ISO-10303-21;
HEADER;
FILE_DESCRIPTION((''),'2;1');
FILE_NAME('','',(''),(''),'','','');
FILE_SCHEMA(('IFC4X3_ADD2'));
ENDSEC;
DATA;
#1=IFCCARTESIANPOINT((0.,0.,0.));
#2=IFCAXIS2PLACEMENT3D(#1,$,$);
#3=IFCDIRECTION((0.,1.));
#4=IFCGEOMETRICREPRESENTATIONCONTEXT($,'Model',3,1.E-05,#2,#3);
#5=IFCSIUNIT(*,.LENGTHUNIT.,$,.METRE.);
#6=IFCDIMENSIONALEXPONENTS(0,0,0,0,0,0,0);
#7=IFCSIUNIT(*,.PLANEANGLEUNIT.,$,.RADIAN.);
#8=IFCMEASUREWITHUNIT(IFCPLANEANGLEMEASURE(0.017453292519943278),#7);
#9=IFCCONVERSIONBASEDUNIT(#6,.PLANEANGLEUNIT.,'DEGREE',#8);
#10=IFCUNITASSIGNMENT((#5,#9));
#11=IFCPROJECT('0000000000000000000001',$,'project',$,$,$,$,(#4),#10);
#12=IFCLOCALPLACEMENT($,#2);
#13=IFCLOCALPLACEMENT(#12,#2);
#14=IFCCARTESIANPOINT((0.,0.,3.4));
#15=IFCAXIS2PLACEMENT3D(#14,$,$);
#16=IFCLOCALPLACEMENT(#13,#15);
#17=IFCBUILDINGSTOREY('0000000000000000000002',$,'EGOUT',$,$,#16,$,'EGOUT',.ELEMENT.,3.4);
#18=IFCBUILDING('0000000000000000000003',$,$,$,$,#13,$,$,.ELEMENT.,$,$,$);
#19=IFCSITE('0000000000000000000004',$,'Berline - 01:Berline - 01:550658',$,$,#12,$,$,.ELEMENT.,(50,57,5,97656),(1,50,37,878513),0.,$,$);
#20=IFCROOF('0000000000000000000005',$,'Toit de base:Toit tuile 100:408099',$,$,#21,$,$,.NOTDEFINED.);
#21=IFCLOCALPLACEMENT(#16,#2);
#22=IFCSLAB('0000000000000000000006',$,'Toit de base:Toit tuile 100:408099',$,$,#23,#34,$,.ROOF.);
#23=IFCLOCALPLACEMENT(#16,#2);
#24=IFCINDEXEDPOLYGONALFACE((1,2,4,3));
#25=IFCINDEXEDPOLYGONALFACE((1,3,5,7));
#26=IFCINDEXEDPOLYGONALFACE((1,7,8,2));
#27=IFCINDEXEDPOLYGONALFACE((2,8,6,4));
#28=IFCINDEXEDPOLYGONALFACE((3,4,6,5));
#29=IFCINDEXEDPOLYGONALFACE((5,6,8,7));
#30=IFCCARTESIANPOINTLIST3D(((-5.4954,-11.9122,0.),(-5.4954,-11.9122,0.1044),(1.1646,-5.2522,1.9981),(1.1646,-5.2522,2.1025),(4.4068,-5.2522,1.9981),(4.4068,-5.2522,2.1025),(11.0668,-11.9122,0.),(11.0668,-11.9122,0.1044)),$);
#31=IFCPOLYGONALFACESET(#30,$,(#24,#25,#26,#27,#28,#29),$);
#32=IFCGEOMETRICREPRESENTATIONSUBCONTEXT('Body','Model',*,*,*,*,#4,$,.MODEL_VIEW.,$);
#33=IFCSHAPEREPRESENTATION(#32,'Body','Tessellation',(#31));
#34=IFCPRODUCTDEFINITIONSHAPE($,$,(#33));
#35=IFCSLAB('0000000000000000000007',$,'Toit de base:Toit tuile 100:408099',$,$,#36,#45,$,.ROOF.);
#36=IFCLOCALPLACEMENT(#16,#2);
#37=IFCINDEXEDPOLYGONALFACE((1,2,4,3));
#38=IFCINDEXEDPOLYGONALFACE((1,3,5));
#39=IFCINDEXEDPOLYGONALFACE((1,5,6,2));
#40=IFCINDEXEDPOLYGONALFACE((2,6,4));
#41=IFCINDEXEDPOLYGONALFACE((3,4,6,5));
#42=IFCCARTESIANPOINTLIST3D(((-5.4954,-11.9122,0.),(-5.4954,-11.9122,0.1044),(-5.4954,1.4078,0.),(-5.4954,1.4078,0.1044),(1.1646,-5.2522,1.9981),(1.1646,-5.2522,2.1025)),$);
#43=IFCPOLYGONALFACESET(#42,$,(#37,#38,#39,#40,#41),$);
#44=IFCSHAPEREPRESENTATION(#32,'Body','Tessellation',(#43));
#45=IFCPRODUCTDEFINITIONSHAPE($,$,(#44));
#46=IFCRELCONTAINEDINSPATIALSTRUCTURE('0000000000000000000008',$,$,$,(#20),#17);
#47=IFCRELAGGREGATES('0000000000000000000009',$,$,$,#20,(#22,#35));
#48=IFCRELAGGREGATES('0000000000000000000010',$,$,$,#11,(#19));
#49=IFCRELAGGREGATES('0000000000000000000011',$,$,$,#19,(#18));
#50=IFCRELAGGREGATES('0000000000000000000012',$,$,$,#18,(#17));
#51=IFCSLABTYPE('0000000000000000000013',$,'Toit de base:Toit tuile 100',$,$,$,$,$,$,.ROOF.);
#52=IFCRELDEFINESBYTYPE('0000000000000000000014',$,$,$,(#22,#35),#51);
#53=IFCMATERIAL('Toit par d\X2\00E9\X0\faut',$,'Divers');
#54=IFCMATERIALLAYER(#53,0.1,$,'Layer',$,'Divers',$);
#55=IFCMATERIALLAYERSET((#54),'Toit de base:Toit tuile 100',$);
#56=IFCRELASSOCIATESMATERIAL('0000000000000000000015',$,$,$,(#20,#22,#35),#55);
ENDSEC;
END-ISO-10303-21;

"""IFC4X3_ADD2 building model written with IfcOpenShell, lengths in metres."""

from ifc_helpers import new_model, entity, si_unit, converted_unit, direction, frame, origin, place, context, subcontext, project, spatial, polyline, outline, extrude, material, layer, layer_set, type_object, element, aggregate, save


model = new_model("IFC4X3_ADD2")

# Units and contexts
model_context = context("Model", 3, precision=1e-05, world=origin(), true_north=direction((0.0, 1.0)))
body_context = subcontext(model_context, "Body", "Model", "MODEL_VIEW")
ifc_project = project(units=[si_unit("LENGTHUNIT", "METRE"), converted_unit("PLANEANGLEUNIT", "DEGREE", entity("IfcPlaneAngleMeasure", 0.017453292519943278), si_unit("PLANEANGLEUNIT", "RADIAN"), dimensions=[0, 0, 0, 0, 0, 0, 0])], contexts=[model_context])

# Site, building, storey
site_placement = place(None, origin())
site = spatial("IfcSite", under=ifc_project, at=site_placement, Name="Berline - 01:Berline - 01:550658", CompositionType="ELEMENT", RefLatitude=(50, 57, 5, 97656), RefLongitude=(1, 50, 37, 878513), RefElevation=0.0)
building_placement = place(site_placement, origin())
building = spatial("IfcBuilding", under=site, at=building_placement, CompositionType="ELEMENT")
storey_placement = place(building_placement, frame((0.0, 0.0, 3.4)))
storey = spatial("IfcBuildingStorey", under=building, at=storey_placement, Name="EGOUT", LongName="EGOUT", CompositionType="ELEMENT", Elevation=3.4)

# Roof, slabs
ifc_material = material(Name="Toit par défaut", Category="Divers")
ifc_layer = layer(ifc_material, 0.1, Name="Layer", Category="Divers")
ifc_layer_set = layer_set([ifc_layer], Name="Toit de base:Toit tuile 100")
roof_placement = place(storey_placement, frame((-5.4954, -11.9122, 0.0)))
roof = element("IfcRoof", 1, at=roof_placement, inside=storey, material=ifc_layer_set, Name="Toit de base:Toit tuile 100:408099", PredefinedType="NOTDEFINED")
slab_type = type_object("IfcSlabType", Name="Toit de base:Toit tuile 100", PredefinedType="ROOF")
slab_1_placement = place(roof_placement, origin())
slab_1 = element("IfcSlab", 2, at=slab_1_placement, type_object=slab_type, material=ifc_layer_set, Name="Toit de base:Toit tuile 100:408099", PredefinedType="ROOF", context=body_context, shape_type="SweptSolid", body=[
    extrude(outline(polyline([(-8.2811, -3.4766), (8.2811, -3.4766), (1.6211, 3.4766), (-1.6211, 3.4766), (-8.2811, -3.4766)])), frame((8.2811, 3.33, 0.999), z_axis=(0.0, -0.287361, 0.957822), x_axis=(1.0, 0.0, 0.0)), (0.0, 0.287361, 0.957822), 0.1044),
])
slab_2_placement = place(roof_placement, origin())
slab_2 = element("IfcSlab", 3, at=slab_2_placement, type_object=slab_type, material=ifc_layer_set, Name="Toit de base:Toit tuile 100:408099", PredefinedType="ROOF", context=body_context, shape_type="SweptSolid", body=[
    extrude(outline(polyline([(-3.4766, 6.66), (-3.4766, -6.66), (3.4766, 0.0), (-3.4766, 6.66)])), frame((3.33, 6.66, 0.999), z_axis=(-0.287361, 0.0, 0.957822), x_axis=(0.957822, 0.0, 0.287361)), (0.287361, 0.0, 0.957822), 0.1044),
])
aggregate(roof, [slab_1, slab_2])

save(model, "model.ifc")
